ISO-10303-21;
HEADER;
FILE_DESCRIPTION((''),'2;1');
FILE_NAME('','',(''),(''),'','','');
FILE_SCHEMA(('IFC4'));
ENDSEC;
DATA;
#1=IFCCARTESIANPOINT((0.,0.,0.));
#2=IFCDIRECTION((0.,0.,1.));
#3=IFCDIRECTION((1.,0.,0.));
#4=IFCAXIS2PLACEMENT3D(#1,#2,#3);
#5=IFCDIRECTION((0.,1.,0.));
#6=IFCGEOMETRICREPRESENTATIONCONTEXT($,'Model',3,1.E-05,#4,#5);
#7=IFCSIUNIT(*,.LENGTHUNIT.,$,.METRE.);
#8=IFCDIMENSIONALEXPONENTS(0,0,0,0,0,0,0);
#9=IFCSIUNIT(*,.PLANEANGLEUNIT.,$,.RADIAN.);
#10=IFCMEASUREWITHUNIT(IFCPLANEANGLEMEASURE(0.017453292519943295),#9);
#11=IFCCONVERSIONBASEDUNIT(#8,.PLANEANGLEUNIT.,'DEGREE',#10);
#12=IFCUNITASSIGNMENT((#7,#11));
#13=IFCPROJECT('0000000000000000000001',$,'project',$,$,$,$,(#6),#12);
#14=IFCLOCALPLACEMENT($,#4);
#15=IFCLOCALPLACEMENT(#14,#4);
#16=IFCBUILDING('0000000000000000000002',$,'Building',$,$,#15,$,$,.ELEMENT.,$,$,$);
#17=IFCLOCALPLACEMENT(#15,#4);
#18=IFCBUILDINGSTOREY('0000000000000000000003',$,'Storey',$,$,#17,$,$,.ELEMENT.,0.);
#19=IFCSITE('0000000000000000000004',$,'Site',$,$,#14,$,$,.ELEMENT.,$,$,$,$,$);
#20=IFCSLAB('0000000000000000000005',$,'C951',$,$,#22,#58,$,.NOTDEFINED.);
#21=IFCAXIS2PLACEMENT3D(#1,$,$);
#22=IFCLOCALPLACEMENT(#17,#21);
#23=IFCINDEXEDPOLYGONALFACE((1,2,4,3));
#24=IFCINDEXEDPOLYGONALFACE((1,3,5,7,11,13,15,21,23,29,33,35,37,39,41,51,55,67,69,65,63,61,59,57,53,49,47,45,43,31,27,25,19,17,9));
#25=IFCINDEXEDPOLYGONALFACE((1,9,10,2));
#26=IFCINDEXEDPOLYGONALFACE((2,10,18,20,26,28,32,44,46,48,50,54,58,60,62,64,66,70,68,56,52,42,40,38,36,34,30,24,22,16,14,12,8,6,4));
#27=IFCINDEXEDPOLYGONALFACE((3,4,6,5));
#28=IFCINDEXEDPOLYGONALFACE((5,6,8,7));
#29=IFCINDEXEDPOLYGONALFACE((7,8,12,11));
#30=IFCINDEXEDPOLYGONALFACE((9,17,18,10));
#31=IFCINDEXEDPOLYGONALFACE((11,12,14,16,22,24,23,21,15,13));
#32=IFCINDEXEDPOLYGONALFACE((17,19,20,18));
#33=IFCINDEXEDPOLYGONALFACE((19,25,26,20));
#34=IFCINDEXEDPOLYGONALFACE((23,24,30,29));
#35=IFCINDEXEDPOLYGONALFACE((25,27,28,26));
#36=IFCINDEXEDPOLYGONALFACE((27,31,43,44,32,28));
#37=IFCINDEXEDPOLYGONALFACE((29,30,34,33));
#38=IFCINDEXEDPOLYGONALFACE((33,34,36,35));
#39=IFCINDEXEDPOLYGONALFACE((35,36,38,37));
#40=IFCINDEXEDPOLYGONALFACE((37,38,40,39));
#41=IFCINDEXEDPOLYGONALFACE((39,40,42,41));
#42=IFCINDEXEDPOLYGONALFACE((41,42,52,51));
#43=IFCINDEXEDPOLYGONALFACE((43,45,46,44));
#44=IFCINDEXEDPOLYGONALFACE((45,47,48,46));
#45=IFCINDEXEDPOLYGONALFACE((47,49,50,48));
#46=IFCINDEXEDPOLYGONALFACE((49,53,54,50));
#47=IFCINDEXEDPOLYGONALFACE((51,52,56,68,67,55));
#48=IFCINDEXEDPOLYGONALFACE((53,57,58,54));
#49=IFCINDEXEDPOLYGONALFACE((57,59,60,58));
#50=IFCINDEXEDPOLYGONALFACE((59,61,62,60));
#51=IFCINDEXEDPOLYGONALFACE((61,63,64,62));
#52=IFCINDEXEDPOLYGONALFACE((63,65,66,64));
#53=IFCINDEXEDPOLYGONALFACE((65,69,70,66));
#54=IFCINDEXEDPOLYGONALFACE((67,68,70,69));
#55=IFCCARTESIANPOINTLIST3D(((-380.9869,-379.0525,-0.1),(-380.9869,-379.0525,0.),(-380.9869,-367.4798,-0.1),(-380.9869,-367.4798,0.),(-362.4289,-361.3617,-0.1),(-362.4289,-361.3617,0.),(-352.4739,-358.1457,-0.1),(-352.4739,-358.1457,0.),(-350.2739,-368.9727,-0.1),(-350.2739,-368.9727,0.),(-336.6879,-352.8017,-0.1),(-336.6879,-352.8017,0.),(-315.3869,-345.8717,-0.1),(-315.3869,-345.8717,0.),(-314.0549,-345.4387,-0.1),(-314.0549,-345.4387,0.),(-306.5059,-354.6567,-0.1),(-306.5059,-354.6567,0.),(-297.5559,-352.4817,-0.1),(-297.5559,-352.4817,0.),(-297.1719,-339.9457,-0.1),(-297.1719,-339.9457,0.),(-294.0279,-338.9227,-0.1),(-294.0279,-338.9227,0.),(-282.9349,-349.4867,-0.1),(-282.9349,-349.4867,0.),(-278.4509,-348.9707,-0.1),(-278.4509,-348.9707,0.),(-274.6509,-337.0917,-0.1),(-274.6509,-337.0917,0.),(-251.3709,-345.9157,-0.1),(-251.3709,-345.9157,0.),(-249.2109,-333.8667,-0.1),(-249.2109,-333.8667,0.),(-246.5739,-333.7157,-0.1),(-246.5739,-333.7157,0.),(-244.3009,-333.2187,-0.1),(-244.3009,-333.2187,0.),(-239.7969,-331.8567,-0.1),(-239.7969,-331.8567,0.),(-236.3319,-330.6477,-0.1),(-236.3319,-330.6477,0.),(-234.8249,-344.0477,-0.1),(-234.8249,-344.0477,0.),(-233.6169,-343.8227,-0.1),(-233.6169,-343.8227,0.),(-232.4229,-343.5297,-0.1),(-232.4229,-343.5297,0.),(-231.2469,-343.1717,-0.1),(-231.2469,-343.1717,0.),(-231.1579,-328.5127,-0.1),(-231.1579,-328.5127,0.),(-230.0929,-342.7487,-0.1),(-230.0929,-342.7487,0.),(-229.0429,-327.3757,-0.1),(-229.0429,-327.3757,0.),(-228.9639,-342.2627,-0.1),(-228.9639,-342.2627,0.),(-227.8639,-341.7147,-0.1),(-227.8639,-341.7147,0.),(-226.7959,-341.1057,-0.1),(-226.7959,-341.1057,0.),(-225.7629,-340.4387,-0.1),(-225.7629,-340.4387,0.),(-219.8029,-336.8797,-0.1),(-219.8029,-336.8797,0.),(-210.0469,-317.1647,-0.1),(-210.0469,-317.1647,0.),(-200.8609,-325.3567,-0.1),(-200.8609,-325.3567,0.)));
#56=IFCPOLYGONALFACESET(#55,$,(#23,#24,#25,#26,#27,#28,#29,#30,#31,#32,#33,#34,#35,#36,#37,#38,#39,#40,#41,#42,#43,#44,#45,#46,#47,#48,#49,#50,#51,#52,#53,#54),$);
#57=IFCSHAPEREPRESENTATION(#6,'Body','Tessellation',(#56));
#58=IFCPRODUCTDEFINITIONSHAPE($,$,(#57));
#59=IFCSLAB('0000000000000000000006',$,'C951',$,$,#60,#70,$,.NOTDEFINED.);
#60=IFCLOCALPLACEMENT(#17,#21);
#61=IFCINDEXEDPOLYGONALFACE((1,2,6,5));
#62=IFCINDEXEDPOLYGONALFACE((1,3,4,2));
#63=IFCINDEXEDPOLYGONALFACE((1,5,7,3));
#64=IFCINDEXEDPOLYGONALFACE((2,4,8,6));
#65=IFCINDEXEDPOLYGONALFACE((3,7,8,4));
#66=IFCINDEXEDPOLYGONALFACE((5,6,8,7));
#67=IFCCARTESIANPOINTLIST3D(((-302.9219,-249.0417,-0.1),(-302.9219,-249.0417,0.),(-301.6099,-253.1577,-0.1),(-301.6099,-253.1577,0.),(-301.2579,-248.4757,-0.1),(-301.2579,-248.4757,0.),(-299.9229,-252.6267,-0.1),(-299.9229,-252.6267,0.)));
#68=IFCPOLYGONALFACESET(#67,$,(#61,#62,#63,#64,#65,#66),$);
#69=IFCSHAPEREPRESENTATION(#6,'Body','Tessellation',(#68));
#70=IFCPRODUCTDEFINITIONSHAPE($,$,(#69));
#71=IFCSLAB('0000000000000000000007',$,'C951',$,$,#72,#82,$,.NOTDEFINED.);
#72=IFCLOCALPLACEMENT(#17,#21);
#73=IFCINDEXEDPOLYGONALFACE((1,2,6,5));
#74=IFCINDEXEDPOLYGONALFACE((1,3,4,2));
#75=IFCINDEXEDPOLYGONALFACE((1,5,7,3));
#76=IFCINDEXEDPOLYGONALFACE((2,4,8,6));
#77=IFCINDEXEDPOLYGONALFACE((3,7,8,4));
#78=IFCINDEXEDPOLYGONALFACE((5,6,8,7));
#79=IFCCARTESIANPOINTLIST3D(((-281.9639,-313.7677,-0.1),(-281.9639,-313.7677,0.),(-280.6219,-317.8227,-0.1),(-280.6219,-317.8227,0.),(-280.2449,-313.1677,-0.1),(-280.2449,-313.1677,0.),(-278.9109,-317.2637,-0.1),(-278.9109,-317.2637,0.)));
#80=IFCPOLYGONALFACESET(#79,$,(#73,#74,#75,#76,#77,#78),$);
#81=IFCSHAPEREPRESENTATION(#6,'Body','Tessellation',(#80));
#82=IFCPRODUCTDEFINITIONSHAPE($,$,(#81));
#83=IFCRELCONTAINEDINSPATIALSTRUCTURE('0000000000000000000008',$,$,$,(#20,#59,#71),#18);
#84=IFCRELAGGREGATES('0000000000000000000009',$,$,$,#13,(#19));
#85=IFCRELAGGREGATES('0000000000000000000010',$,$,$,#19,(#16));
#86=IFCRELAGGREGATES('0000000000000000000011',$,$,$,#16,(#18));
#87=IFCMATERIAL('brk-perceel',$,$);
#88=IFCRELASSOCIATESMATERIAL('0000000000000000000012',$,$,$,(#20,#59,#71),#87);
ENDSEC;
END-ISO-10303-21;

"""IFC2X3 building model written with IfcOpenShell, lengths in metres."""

from ifc_helpers import new_model, entity, si_unit, converted_unit, direction, frame, origin_with_axes, place, context, project, spatial, polyline, outline, extrude, material, element, save


model = new_model("IFC2X3")

# Units and contexts
model_context = context("Model", 3, precision=1e-05, world=origin_with_axes(), true_north=direction((0.0, 1.0, 0.0)))
ifc_project = project(units=[si_unit("LENGTHUNIT", "METRE"), converted_unit("PLANEANGLEUNIT", "DEGREE", entity("IfcPlaneAngleMeasure", 0.017453292519943295), si_unit("PLANEANGLEUNIT", "RADIAN"), dimensions=[0, 0, 0, 0, 0, 0, 0])], contexts=[model_context])

# Site, building, storey
site_placement = place(None, origin_with_axes())
site = spatial("IfcSite", under=ifc_project, at=site_placement, Name="Site", CompositionType="ELEMENT")
building_placement = place(site_placement, origin_with_axes())
building = spatial("IfcBuilding", under=site, at=building_placement, Name="Building", CompositionType="ELEMENT")
storey_placement = place(building_placement, origin_with_axes())
storey = spatial("IfcBuildingStorey", under=building, at=storey_placement, Name="Storey", CompositionType="ELEMENT", Elevation=0.0)

# Slabs
ifc_material = material(Name="brk-perceel")
slab_1_placement = place(storey_placement, frame((0.0, 0.0, -0.1), z_axis=(0.0, 0.0, 1.0), x_axis=(1.0, 0.0, 0.0)))
element("IfcSlab", 1, at=slab_1_placement, inside=storey, material=ifc_material, Name="C951", PredefinedType="NOTDEFINED", context=model_context, shape_type="SweptSolid", body=[
    extrude(outline(polyline([(-362.4289, -361.3617), (-352.4739, -358.1457), (-336.6879, -352.8017), (-315.3869, -345.8717), (-314.0549, -345.4387), (-297.1719, -339.9457), (-294.0279, -338.9227), (-274.6509, -337.0917), (-249.2109, -333.8667), (-246.5739, -333.7157), (-244.3009, -333.2187), (-239.7969, -331.8567), (-236.3319, -330.6477), (-231.1579, -328.5127), (-229.0429, -327.3757), (-210.0469, -317.1647), (-200.8609, -325.3567), (-219.8029, -336.8797), (-225.7629, -340.4387), (-226.7959, -341.1057), (-227.8639, -341.7147), (-228.9639, -342.2627), (-230.0929, -342.7487), (-231.2469, -343.1717), (-232.4229, -343.5297), (-233.6169, -343.8227), (-234.8249, -344.0477), (-251.3709, -345.9157), (-278.4509, -348.9707), (-282.9349, -349.4867), (-297.5559, -352.4817), (-306.5059, -354.6567), (-350.2739, -368.9727), (-380.9869, -379.0525), (-380.9869, -367.4798), (-362.4289, -361.3617)])), origin_with_axes(), (0.0, 0.0, 1.0), 0.1),
])
slab_2_placement = place(storey_placement, frame((0.0, 0.0, -0.1), z_axis=(0.0, 0.0, 1.0), x_axis=(1.0, 0.0, 0.0)))
element("IfcSlab", 2, at=slab_2_placement, inside=storey, material=ifc_material, Name="C951", PredefinedType="NOTDEFINED", context=model_context, shape_type="SweptSolid", body=[
    extrude(outline(polyline([(-301.6099, -253.1577), (-302.9219, -249.0417), (-301.2579, -248.4757), (-299.9229, -252.6267), (-301.6099, -253.1577)])), origin_with_axes(), (0.0, 0.0, 1.0), 0.1),
])
slab_3_placement = place(storey_placement, frame((0.0, 0.0, -0.1), z_axis=(0.0, 0.0, 1.0), x_axis=(1.0, 0.0, 0.0)))
element("IfcSlab", 3, at=slab_3_placement, inside=storey, material=ifc_material, Name="C951", PredefinedType="NOTDEFINED", context=model_context, shape_type="SweptSolid", body=[
    extrude(outline(polyline([(-280.6219, -317.8227), (-281.9639, -313.7677), (-280.2449, -313.1677), (-278.9109, -317.2637), (-280.6219, -317.8227)])), origin_with_axes(), (0.0, 0.0, 1.0), 0.1),
])

save(model, "model.ifc")
